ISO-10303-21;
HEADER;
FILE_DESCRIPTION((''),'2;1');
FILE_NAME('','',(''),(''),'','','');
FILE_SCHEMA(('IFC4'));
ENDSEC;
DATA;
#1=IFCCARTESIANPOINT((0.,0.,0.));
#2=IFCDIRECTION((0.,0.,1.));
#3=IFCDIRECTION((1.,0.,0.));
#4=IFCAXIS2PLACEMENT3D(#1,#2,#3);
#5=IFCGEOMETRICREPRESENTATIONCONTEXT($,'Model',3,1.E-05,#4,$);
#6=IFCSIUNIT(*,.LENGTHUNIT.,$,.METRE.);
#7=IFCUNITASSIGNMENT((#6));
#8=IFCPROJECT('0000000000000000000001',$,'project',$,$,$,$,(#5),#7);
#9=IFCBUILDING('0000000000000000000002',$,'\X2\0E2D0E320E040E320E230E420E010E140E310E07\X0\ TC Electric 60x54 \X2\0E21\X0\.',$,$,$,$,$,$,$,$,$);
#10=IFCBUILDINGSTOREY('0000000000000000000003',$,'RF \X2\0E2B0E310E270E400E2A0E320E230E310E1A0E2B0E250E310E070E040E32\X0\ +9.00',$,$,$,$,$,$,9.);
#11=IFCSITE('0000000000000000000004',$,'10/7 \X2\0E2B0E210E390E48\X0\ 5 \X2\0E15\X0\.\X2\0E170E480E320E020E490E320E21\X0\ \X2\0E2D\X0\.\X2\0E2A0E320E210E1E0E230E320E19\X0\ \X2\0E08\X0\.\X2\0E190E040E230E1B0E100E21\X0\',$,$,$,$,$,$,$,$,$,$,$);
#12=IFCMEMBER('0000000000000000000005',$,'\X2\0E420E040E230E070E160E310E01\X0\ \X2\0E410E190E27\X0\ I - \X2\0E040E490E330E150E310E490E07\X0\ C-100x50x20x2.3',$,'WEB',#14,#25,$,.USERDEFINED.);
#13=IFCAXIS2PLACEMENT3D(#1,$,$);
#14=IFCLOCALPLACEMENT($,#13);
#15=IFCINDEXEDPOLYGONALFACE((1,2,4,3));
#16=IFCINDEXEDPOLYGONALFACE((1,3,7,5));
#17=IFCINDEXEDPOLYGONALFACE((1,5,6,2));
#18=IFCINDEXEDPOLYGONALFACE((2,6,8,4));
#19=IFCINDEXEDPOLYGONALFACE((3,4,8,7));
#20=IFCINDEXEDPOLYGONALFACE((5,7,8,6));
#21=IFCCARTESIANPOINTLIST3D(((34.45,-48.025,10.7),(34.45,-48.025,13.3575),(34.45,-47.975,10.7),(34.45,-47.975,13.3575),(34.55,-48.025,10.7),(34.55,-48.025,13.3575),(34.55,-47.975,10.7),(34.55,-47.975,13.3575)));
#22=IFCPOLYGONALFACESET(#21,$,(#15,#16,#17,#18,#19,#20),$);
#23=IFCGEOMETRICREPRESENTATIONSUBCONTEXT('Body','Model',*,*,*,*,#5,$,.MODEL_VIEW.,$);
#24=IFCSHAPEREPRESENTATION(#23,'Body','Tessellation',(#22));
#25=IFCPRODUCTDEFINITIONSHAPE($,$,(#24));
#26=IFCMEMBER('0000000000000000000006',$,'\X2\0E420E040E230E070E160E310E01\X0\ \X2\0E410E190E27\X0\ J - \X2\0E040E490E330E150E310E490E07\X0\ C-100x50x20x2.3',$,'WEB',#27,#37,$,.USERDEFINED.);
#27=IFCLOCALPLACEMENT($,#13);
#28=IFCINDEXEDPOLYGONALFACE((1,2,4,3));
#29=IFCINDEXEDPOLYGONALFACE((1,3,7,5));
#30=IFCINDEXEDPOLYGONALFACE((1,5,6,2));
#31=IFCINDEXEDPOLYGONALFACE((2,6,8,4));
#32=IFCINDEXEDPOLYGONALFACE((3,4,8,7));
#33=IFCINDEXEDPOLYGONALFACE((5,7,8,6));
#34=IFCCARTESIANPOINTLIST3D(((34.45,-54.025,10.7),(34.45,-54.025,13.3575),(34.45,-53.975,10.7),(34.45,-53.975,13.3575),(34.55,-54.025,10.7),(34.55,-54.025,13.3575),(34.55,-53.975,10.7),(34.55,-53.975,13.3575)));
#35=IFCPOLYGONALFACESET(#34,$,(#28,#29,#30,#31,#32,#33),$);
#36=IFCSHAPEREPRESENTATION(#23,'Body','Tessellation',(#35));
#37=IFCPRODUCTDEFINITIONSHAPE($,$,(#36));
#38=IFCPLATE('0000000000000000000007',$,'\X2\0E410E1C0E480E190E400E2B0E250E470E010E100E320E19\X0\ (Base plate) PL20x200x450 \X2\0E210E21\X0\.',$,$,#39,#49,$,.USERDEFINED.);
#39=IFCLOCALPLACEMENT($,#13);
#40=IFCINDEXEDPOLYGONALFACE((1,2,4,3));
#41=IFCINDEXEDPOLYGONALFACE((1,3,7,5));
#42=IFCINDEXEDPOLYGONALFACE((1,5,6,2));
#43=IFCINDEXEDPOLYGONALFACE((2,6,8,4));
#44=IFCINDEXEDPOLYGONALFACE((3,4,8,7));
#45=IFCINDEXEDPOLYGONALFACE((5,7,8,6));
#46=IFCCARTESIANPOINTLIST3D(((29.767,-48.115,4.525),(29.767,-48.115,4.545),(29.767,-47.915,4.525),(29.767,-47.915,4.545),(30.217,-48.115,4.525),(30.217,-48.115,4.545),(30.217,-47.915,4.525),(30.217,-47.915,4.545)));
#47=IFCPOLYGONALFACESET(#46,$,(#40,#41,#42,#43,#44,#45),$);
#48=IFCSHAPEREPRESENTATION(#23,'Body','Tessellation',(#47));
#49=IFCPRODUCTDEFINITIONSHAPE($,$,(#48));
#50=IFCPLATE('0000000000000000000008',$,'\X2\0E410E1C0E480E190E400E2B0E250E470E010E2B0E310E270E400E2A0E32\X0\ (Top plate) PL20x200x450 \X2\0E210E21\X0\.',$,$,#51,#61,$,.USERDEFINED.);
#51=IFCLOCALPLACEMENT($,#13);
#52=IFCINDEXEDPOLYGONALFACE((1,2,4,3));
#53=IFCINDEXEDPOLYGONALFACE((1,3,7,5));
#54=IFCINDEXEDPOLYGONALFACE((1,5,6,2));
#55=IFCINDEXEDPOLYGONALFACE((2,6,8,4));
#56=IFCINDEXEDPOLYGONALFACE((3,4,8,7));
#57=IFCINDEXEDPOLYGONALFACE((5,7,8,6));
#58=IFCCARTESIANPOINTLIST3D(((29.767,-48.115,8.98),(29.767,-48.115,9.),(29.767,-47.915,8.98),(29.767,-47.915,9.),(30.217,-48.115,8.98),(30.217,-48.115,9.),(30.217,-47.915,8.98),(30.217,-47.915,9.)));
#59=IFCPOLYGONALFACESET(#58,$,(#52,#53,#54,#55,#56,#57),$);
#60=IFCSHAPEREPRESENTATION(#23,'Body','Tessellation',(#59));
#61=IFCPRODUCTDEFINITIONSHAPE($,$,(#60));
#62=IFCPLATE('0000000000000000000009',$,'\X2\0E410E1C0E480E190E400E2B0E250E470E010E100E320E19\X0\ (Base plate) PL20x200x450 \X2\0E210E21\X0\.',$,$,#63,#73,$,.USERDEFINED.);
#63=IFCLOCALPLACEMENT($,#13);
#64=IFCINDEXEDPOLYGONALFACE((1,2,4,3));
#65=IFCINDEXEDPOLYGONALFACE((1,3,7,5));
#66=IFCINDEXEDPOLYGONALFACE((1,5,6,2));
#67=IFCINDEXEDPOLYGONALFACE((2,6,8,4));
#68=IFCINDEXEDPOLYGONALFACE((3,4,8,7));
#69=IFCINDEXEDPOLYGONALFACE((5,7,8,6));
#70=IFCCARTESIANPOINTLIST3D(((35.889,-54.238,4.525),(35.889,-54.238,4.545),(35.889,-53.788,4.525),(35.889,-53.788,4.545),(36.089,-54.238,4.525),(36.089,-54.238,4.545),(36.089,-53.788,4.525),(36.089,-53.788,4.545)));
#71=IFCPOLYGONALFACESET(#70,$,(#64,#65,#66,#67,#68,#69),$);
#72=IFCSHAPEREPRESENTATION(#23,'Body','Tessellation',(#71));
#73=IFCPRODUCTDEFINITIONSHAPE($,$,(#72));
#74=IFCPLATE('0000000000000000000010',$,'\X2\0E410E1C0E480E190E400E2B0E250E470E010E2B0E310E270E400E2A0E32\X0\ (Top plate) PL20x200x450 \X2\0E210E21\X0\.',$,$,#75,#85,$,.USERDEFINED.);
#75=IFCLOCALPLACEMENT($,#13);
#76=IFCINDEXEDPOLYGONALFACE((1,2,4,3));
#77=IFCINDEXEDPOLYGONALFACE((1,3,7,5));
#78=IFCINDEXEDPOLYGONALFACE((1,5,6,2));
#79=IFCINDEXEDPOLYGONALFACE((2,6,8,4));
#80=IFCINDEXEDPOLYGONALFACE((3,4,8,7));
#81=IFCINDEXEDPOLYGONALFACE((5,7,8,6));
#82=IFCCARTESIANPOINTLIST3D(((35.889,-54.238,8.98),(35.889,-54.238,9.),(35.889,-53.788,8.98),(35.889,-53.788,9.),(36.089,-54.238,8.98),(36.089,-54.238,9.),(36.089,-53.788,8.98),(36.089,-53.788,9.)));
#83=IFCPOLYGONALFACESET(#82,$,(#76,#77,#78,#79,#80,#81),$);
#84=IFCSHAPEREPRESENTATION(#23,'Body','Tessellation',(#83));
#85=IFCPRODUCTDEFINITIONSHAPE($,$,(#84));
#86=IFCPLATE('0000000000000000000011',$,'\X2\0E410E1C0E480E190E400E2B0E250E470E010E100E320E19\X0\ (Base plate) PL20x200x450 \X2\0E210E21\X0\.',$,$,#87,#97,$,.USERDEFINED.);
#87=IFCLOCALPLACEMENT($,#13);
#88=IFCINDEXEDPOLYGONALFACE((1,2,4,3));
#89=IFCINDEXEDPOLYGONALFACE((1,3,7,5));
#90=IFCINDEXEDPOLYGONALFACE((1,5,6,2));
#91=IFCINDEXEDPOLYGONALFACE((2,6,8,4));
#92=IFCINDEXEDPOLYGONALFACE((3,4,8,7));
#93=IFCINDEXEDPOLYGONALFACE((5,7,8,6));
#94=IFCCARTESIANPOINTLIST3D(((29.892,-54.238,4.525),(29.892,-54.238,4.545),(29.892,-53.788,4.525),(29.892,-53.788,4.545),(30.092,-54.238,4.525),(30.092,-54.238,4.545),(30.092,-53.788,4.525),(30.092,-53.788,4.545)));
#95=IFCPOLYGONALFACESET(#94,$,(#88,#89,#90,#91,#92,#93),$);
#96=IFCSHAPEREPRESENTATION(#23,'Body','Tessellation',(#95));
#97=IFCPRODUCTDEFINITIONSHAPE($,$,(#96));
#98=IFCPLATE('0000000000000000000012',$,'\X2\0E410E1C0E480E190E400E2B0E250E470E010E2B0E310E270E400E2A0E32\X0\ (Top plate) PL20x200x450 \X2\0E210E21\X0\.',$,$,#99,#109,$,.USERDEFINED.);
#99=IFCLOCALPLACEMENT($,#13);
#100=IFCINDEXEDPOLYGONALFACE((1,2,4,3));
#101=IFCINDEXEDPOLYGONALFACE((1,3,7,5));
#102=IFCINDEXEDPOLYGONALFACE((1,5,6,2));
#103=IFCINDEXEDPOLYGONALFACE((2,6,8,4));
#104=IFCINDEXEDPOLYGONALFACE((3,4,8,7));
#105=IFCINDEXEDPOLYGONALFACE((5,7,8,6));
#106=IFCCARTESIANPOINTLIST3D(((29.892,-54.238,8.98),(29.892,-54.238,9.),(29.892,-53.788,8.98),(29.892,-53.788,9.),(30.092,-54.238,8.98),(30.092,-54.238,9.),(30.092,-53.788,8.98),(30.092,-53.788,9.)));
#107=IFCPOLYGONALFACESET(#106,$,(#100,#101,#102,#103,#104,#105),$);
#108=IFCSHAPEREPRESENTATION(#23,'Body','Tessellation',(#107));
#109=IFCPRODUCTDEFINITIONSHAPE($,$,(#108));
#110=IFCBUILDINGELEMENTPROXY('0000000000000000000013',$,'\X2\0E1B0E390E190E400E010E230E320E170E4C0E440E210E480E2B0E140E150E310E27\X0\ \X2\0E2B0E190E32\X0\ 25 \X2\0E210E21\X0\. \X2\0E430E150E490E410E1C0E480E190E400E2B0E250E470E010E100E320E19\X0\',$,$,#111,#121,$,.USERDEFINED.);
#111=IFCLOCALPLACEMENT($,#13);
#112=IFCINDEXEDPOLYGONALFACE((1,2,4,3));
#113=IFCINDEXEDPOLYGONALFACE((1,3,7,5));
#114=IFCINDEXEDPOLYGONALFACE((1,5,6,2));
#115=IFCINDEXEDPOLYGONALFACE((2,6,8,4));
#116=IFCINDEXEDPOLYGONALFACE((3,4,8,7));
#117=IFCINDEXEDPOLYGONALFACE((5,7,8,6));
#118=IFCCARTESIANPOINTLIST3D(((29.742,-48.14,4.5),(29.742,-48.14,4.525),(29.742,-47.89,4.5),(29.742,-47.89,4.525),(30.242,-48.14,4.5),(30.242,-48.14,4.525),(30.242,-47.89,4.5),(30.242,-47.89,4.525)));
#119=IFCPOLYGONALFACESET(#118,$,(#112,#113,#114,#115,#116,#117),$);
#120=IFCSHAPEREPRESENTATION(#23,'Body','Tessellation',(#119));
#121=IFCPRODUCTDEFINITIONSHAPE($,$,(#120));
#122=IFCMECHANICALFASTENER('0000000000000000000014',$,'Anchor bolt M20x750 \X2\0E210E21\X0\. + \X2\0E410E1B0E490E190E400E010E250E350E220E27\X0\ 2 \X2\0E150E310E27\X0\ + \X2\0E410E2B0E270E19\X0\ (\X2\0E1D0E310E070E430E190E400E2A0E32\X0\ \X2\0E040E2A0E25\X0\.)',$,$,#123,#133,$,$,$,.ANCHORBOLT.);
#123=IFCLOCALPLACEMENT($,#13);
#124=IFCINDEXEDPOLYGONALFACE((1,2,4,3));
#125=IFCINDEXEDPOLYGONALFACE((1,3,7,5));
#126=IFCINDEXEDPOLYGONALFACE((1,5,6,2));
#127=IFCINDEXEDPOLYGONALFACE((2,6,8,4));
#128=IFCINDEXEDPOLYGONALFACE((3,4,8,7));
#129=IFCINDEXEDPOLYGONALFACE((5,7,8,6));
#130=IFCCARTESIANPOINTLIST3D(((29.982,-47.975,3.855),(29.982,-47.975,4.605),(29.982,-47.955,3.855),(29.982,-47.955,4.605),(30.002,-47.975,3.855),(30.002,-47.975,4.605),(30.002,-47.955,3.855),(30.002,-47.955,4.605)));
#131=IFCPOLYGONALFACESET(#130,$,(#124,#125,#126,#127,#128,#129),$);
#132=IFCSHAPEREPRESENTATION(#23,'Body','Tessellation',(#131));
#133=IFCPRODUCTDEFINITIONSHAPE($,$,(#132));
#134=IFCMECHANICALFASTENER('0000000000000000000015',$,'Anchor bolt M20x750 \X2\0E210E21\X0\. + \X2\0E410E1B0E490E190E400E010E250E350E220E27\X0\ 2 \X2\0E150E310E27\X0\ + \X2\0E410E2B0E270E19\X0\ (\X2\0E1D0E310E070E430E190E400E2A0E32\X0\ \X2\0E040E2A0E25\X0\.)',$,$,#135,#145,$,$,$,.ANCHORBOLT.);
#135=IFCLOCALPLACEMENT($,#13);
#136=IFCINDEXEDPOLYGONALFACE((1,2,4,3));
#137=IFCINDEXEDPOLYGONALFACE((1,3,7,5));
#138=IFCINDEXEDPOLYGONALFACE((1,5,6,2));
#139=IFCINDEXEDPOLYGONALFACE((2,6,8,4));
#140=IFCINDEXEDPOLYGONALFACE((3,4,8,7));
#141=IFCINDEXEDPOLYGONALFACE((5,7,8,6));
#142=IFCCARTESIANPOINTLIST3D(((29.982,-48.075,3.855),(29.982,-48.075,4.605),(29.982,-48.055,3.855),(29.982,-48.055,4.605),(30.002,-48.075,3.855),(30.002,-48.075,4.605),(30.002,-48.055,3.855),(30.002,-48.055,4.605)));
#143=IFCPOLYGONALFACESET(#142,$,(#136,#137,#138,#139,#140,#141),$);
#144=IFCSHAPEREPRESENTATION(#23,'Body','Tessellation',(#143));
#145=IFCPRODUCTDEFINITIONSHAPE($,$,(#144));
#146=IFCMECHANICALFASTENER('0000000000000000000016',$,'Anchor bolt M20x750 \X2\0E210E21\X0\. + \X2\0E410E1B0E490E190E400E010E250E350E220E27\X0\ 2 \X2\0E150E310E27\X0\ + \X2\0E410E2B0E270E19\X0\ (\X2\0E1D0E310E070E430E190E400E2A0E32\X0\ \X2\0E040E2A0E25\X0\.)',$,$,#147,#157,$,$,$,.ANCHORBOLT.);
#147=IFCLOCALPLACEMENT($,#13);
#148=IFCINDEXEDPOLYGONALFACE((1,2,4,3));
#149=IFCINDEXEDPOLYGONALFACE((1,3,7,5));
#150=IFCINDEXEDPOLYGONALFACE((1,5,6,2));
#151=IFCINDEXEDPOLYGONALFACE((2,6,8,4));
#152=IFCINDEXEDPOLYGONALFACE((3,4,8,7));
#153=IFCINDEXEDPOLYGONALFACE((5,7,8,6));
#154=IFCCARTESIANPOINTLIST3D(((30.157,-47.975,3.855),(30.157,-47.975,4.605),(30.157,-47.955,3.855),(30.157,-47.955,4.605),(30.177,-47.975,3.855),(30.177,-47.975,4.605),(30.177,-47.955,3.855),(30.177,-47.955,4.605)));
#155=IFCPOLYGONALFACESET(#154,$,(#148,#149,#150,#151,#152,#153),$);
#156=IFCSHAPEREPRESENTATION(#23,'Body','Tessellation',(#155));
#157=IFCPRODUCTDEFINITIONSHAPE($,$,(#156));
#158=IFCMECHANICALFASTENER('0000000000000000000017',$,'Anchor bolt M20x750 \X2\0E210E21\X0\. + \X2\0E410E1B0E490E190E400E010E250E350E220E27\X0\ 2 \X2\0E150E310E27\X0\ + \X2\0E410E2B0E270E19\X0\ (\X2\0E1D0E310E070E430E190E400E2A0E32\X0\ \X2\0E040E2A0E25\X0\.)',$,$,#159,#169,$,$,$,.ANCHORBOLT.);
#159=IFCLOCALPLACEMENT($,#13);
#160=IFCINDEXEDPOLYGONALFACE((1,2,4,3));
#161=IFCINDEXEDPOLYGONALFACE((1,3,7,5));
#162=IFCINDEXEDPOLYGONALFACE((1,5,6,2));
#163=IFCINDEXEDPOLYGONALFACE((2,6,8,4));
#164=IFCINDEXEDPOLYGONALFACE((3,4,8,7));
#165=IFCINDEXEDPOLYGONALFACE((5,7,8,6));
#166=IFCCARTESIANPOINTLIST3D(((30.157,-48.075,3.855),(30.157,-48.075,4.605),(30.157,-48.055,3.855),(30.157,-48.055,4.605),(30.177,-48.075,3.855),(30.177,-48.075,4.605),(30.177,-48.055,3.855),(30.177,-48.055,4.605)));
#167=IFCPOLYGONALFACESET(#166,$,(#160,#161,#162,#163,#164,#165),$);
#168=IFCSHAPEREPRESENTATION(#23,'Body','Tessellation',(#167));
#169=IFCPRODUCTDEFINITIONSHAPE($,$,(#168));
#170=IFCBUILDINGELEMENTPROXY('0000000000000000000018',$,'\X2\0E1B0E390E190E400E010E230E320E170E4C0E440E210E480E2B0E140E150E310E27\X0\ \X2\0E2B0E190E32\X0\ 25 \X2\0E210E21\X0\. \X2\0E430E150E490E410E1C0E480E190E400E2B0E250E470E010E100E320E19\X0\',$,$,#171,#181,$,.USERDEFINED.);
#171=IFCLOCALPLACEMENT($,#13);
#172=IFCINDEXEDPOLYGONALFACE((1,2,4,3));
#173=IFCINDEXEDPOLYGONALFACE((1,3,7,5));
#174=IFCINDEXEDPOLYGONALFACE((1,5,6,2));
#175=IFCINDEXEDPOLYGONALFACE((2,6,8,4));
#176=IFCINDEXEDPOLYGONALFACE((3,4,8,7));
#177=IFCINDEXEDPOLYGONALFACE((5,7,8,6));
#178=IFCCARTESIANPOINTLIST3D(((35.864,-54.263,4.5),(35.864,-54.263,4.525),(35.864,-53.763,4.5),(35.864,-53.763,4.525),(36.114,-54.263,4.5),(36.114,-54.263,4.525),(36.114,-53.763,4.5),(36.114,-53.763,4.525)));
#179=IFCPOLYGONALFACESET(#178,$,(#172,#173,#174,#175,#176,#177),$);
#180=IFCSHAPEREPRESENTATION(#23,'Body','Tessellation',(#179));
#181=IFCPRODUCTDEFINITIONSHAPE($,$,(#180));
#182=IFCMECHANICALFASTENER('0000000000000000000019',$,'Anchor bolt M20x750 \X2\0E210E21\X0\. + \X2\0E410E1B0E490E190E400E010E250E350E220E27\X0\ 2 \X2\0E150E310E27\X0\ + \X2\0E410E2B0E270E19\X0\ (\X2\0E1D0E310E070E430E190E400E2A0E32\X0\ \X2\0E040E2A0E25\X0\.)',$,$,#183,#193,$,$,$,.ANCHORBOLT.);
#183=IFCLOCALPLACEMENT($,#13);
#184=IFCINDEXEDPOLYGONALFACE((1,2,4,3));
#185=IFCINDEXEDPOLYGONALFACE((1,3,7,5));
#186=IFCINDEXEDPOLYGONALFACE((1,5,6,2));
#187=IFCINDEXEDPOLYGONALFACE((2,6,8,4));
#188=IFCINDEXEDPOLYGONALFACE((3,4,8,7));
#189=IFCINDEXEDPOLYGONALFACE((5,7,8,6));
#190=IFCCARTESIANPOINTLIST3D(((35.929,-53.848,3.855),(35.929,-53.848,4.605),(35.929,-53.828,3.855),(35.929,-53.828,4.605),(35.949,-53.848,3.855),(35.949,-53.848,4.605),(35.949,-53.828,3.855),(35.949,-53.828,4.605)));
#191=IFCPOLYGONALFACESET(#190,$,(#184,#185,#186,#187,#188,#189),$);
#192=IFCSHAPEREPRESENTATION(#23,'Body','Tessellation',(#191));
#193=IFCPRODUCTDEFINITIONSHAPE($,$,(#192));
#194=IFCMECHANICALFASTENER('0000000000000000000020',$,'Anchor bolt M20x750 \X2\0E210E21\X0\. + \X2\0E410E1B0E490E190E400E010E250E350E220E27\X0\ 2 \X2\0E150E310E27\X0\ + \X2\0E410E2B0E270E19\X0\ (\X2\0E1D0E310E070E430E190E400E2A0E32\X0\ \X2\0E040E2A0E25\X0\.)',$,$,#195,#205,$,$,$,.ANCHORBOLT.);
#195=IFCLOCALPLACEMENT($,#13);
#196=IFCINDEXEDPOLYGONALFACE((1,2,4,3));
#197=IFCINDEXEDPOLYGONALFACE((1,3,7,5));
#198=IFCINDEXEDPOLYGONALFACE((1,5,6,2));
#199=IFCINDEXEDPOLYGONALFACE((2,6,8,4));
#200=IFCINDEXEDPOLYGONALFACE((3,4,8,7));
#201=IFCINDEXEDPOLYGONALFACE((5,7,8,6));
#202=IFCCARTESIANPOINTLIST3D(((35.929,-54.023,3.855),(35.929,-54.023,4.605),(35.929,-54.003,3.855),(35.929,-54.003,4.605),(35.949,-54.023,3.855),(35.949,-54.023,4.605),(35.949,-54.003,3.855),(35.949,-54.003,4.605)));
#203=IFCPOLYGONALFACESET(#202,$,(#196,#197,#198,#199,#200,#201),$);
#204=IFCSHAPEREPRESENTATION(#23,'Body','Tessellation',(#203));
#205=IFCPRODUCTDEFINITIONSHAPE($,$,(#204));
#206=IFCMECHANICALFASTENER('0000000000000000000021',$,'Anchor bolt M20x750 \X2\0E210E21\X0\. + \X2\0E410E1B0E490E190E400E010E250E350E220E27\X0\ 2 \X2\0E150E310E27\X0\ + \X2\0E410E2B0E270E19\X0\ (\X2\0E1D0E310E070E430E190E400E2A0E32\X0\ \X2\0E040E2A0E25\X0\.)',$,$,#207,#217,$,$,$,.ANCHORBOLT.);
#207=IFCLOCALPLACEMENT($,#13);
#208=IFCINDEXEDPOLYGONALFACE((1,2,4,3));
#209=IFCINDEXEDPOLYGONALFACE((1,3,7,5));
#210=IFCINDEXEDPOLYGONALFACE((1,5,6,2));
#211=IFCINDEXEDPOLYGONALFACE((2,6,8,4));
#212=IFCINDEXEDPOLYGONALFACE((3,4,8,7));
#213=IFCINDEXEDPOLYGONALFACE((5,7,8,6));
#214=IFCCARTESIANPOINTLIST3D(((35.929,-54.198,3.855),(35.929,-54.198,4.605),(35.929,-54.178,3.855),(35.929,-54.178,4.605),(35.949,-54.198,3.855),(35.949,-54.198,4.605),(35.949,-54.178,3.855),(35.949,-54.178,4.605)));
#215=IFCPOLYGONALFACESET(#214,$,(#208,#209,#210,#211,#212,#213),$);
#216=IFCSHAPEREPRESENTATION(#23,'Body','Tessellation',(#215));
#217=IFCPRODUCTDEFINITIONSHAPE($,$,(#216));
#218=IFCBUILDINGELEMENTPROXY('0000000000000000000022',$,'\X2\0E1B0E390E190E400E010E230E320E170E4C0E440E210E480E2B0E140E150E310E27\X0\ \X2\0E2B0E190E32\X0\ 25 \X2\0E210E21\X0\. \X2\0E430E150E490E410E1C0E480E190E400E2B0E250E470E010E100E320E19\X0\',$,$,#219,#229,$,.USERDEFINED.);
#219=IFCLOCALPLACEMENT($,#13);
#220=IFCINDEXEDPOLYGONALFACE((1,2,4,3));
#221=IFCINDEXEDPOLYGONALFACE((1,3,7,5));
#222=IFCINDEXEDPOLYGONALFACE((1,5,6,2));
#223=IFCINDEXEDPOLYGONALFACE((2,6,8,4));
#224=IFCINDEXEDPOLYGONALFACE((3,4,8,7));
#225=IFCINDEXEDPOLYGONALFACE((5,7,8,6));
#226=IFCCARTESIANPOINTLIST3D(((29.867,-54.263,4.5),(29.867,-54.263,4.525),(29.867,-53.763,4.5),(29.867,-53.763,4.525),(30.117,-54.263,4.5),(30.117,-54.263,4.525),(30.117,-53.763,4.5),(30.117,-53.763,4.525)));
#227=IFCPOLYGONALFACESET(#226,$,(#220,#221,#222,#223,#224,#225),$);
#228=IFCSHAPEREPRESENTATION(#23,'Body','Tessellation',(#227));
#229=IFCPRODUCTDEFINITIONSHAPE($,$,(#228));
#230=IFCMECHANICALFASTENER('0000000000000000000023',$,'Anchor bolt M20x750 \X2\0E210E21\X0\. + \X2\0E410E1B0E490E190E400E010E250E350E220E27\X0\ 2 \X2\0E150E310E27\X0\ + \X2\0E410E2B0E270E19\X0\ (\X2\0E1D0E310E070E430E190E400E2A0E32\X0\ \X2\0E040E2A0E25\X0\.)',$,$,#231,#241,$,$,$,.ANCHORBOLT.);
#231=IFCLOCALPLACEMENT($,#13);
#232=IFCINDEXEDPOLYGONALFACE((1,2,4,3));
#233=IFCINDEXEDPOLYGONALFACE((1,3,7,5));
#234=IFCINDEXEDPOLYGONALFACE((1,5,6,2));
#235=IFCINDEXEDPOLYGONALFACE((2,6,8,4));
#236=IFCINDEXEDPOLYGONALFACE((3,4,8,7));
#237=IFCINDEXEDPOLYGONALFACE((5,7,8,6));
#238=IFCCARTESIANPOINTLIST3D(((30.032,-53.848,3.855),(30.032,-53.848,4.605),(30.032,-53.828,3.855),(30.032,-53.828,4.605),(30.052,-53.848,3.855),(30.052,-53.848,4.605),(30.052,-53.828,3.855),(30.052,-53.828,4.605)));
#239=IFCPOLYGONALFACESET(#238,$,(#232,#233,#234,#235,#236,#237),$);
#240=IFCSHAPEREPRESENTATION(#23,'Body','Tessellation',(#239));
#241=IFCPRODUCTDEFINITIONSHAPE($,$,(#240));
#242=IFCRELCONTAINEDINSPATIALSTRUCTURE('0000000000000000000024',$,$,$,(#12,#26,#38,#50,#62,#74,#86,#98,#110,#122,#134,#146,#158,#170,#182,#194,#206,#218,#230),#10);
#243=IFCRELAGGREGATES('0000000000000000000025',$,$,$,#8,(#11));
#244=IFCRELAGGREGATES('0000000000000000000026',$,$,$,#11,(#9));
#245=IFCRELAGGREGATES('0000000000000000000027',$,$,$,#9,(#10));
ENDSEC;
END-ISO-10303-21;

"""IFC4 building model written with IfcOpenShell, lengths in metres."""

from ifc_helpers import new_model, si_unit, frame, origin, origin_with_axes, origin_2d, place, context, subcontext, project, spatial, rectangle, extrude, element, save


model = new_model("IFC4")

# Units and contexts
model_context = context("Model", 3, precision=1e-05, world=origin_with_axes())
body_context = subcontext(model_context, "Body", "Model", "MODEL_VIEW")
ifc_project = project(units=[si_unit("LENGTHUNIT", "METRE")], contexts=[model_context])

# Site, building, storey
site = spatial("IfcSite", under=ifc_project, Name="10/7 หมู่ 5 ต.ท่าข้าม อ.สามพราน จ.นครปฐม")
building = spatial("IfcBuilding", under=site, Name="อาคารโกดัง TC Electric 60x54 ม.")
storey = spatial("IfcBuildingStorey", under=building, Name="RF หัวเสารับหลังคา +9.00", Elevation=9.0)

# Members
for number, where, z_axis, x_axis, name in (
    (1, (34.5, -48.0, 10.7), (0.0, 0.0, 1.0), (0.0, 1.0, 0.0), "โครงถัก แนว I - ค้ำตั้ง C-100x50x20x2.3"),
    (2, (34.5, -54.0, 10.7), (0.0, 0.0, 1.0), (0.0, 1.0, 0.0), "โครงถัก แนว J - ค้ำตั้ง C-100x50x20x2.3"),
):
    element("IfcMember", number, at=place(None, frame(where, z_axis=z_axis, x_axis=x_axis)), inside=storey, Name=name, ObjectType="WEB", PredefinedType="USERDEFINED", context=body_context, shape_type="SweptSolid", body=[
        extrude(rectangle(XDim=0.05, YDim=0.1, at=origin_2d()), origin(), (0.0, 0.0, 1.0), 2.6575),
    ])

# Plates
for number, where, z_axis, x_axis, name in (
    (3, (29.992, -48.015, 4.525), (0.0, 0.0, 1.0), (1.0, 0.0, 0.0), "แผ่นเหล็กฐาน (Base plate) PL20x200x450 มม."),
    (4, (29.992, -48.015, 8.98), (0.0, 0.0, 1.0), (1.0, 0.0, 0.0), "แผ่นเหล็กหัวเสา (Top plate) PL20x200x450 มม."),
):
    element("IfcPlate", number, at=place(None, frame(where, z_axis=z_axis, x_axis=x_axis)), inside=storey, Name=name, PredefinedType="USERDEFINED", context=body_context, shape_type="SweptSolid", body=[
        extrude(rectangle(XDim=0.45, YDim=0.2, at=origin_2d()), origin(), (0.0, 0.0, 1.0), 0.02),
    ])
for number, where, z_axis, x_axis, name in (
    (5, (35.989, -54.013, 4.525), (0.0, 0.0, 1.0), (1.0, 0.0, 0.0), "แผ่นเหล็กฐาน (Base plate) PL20x200x450 มม."),
    (6, (35.989, -54.013, 8.98), (0.0, 0.0, 1.0), (1.0, 0.0, 0.0), "แผ่นเหล็กหัวเสา (Top plate) PL20x200x450 มม."),
    (7, (29.992, -54.013, 4.525), (0.0, 0.0, 1.0), (1.0, 0.0, 0.0), "แผ่นเหล็กฐาน (Base plate) PL20x200x450 มม."),
    (8, (29.992, -54.013, 8.98), (0.0, 0.0, 1.0), (1.0, 0.0, 0.0), "แผ่นเหล็กหัวเสา (Top plate) PL20x200x450 มม."),
):
    element("IfcPlate", number, at=place(None, frame(where, z_axis=z_axis, x_axis=x_axis)), inside=storey, Name=name, PredefinedType="USERDEFINED", context=body_context, shape_type="SweptSolid", body=[
        extrude(rectangle(XDim=0.2, YDim=0.45, at=origin_2d()), origin(), (0.0, 0.0, 1.0), 0.02),
    ])

# Building element proxy
proxy_1_placement = place(None, frame((29.992, -48.015, 4.5), z_axis=(0.0, 0.0, 1.0), x_axis=(1.0, 0.0, 0.0)))
element("IfcBuildingElementProxy", 9, at=proxy_1_placement, inside=storey, Name="ปูนเกราท์ไม่หดตัว หนา 25 มม. ใต้แผ่นเหล็กฐาน", PredefinedType="USERDEFINED", context=body_context, shape_type="SweptSolid", body=[
    extrude(rectangle(XDim=0.5, YDim=0.25, at=origin_2d()), origin(), (0.0, 0.0, 1.0), 0.025),
])

# Mechanical fasteners
for number, where, z_axis, x_axis, name in (
    (10, (29.992, -47.965, 3.855), (0.0, 0.0, 1.0), (1.0, 0.0, 0.0), "Anchor bolt M20x750 มม. + แป้นเกลียว 2 ตัว + แหวน (ฝังในเสา คสล.)"),
    (11, (29.992, -48.065, 3.855), (0.0, 0.0, 1.0), (1.0, 0.0, 0.0), "Anchor bolt M20x750 มม. + แป้นเกลียว 2 ตัว + แหวน (ฝังในเสา คสล.)"),
    (12, (30.167, -47.965, 3.855), (0.0, 0.0, 1.0), (1.0, 0.0, 0.0), "Anchor bolt M20x750 มม. + แป้นเกลียว 2 ตัว + แหวน (ฝังในเสา คสล.)"),
    (13, (30.167, -48.065, 3.855), (0.0, 0.0, 1.0), (1.0, 0.0, 0.0), "Anchor bolt M20x750 มม. + แป้นเกลียว 2 ตัว + แหวน (ฝังในเสา คสล.)"),
):
    element("IfcMechanicalFastener", number, at=place(None, frame(where, z_axis=z_axis, x_axis=x_axis)), inside=storey, Name=name, PredefinedType="ANCHORBOLT", context=body_context, shape_type="SweptSolid", body=[
        extrude(rectangle(XDim=0.02, YDim=0.02, at=origin_2d()), origin(), (0.0, 0.0, 1.0), 0.75),
    ])

# Building element proxy
proxy_2_placement = place(None, frame((35.989, -54.013, 4.5), z_axis=(0.0, 0.0, 1.0), x_axis=(1.0, 0.0, 0.0)))
element("IfcBuildingElementProxy", 14, at=proxy_2_placement, inside=storey, Name="ปูนเกราท์ไม่หดตัว หนา 25 มม. ใต้แผ่นเหล็กฐาน", PredefinedType="USERDEFINED", context=body_context, shape_type="SweptSolid", body=[
    extrude(rectangle(XDim=0.25, YDim=0.5, at=origin_2d()), origin(), (0.0, 0.0, 1.0), 0.025),
])

# Mechanical fasteners
for number, where, z_axis, x_axis, name in (
    (15, (35.939, -53.838, 3.855), (0.0, 0.0, 1.0), (1.0, 0.0, 0.0), "Anchor bolt M20x750 มม. + แป้นเกลียว 2 ตัว + แหวน (ฝังในเสา คสล.)"),
    (16, (35.939, -54.013, 3.855), (0.0, 0.0, 1.0), (1.0, 0.0, 0.0), "Anchor bolt M20x750 มม. + แป้นเกลียว 2 ตัว + แหวน (ฝังในเสา คสล.)"),
    (17, (35.939, -54.188, 3.855), (0.0, 0.0, 1.0), (1.0, 0.0, 0.0), "Anchor bolt M20x750 มม. + แป้นเกลียว 2 ตัว + แหวน (ฝังในเสา คสล.)"),
):
    element("IfcMechanicalFastener", number, at=place(None, frame(where, z_axis=z_axis, x_axis=x_axis)), inside=storey, Name=name, PredefinedType="ANCHORBOLT", context=body_context, shape_type="SweptSolid", body=[
        extrude(rectangle(XDim=0.02, YDim=0.02, at=origin_2d()), origin(), (0.0, 0.0, 1.0), 0.75),
    ])

# Building element proxy
proxy_3_placement = place(None, frame((29.992, -54.013, 4.5), z_axis=(0.0, 0.0, 1.0), x_axis=(1.0, 0.0, 0.0)))
element("IfcBuildingElementProxy", 18, at=proxy_3_placement, inside=storey, Name="ปูนเกราท์ไม่หดตัว หนา 25 มม. ใต้แผ่นเหล็กฐาน", PredefinedType="USERDEFINED", context=body_context, shape_type="SweptSolid", body=[
    extrude(rectangle(XDim=0.25, YDim=0.5, at=origin_2d()), origin(), (0.0, 0.0, 1.0), 0.025),
])

# Mechanical fastener
for number, where, z_axis, x_axis, name in (
    (19, (30.042, -53.838, 3.855), (0.0, 0.0, 1.0), (1.0, 0.0, 0.0), "Anchor bolt M20x750 มม. + แป้นเกลียว 2 ตัว + แหวน (ฝังในเสา คสล.)"),
):
    element("IfcMechanicalFastener", number, at=place(None, frame(where, z_axis=z_axis, x_axis=x_axis)), inside=storey, Name=name, PredefinedType="ANCHORBOLT", context=body_context, shape_type="SweptSolid", body=[
        extrude(rectangle(XDim=0.02, YDim=0.02, at=origin_2d()), origin(), (0.0, 0.0, 1.0), 0.75),
    ])

save(model, "model.ifc")
